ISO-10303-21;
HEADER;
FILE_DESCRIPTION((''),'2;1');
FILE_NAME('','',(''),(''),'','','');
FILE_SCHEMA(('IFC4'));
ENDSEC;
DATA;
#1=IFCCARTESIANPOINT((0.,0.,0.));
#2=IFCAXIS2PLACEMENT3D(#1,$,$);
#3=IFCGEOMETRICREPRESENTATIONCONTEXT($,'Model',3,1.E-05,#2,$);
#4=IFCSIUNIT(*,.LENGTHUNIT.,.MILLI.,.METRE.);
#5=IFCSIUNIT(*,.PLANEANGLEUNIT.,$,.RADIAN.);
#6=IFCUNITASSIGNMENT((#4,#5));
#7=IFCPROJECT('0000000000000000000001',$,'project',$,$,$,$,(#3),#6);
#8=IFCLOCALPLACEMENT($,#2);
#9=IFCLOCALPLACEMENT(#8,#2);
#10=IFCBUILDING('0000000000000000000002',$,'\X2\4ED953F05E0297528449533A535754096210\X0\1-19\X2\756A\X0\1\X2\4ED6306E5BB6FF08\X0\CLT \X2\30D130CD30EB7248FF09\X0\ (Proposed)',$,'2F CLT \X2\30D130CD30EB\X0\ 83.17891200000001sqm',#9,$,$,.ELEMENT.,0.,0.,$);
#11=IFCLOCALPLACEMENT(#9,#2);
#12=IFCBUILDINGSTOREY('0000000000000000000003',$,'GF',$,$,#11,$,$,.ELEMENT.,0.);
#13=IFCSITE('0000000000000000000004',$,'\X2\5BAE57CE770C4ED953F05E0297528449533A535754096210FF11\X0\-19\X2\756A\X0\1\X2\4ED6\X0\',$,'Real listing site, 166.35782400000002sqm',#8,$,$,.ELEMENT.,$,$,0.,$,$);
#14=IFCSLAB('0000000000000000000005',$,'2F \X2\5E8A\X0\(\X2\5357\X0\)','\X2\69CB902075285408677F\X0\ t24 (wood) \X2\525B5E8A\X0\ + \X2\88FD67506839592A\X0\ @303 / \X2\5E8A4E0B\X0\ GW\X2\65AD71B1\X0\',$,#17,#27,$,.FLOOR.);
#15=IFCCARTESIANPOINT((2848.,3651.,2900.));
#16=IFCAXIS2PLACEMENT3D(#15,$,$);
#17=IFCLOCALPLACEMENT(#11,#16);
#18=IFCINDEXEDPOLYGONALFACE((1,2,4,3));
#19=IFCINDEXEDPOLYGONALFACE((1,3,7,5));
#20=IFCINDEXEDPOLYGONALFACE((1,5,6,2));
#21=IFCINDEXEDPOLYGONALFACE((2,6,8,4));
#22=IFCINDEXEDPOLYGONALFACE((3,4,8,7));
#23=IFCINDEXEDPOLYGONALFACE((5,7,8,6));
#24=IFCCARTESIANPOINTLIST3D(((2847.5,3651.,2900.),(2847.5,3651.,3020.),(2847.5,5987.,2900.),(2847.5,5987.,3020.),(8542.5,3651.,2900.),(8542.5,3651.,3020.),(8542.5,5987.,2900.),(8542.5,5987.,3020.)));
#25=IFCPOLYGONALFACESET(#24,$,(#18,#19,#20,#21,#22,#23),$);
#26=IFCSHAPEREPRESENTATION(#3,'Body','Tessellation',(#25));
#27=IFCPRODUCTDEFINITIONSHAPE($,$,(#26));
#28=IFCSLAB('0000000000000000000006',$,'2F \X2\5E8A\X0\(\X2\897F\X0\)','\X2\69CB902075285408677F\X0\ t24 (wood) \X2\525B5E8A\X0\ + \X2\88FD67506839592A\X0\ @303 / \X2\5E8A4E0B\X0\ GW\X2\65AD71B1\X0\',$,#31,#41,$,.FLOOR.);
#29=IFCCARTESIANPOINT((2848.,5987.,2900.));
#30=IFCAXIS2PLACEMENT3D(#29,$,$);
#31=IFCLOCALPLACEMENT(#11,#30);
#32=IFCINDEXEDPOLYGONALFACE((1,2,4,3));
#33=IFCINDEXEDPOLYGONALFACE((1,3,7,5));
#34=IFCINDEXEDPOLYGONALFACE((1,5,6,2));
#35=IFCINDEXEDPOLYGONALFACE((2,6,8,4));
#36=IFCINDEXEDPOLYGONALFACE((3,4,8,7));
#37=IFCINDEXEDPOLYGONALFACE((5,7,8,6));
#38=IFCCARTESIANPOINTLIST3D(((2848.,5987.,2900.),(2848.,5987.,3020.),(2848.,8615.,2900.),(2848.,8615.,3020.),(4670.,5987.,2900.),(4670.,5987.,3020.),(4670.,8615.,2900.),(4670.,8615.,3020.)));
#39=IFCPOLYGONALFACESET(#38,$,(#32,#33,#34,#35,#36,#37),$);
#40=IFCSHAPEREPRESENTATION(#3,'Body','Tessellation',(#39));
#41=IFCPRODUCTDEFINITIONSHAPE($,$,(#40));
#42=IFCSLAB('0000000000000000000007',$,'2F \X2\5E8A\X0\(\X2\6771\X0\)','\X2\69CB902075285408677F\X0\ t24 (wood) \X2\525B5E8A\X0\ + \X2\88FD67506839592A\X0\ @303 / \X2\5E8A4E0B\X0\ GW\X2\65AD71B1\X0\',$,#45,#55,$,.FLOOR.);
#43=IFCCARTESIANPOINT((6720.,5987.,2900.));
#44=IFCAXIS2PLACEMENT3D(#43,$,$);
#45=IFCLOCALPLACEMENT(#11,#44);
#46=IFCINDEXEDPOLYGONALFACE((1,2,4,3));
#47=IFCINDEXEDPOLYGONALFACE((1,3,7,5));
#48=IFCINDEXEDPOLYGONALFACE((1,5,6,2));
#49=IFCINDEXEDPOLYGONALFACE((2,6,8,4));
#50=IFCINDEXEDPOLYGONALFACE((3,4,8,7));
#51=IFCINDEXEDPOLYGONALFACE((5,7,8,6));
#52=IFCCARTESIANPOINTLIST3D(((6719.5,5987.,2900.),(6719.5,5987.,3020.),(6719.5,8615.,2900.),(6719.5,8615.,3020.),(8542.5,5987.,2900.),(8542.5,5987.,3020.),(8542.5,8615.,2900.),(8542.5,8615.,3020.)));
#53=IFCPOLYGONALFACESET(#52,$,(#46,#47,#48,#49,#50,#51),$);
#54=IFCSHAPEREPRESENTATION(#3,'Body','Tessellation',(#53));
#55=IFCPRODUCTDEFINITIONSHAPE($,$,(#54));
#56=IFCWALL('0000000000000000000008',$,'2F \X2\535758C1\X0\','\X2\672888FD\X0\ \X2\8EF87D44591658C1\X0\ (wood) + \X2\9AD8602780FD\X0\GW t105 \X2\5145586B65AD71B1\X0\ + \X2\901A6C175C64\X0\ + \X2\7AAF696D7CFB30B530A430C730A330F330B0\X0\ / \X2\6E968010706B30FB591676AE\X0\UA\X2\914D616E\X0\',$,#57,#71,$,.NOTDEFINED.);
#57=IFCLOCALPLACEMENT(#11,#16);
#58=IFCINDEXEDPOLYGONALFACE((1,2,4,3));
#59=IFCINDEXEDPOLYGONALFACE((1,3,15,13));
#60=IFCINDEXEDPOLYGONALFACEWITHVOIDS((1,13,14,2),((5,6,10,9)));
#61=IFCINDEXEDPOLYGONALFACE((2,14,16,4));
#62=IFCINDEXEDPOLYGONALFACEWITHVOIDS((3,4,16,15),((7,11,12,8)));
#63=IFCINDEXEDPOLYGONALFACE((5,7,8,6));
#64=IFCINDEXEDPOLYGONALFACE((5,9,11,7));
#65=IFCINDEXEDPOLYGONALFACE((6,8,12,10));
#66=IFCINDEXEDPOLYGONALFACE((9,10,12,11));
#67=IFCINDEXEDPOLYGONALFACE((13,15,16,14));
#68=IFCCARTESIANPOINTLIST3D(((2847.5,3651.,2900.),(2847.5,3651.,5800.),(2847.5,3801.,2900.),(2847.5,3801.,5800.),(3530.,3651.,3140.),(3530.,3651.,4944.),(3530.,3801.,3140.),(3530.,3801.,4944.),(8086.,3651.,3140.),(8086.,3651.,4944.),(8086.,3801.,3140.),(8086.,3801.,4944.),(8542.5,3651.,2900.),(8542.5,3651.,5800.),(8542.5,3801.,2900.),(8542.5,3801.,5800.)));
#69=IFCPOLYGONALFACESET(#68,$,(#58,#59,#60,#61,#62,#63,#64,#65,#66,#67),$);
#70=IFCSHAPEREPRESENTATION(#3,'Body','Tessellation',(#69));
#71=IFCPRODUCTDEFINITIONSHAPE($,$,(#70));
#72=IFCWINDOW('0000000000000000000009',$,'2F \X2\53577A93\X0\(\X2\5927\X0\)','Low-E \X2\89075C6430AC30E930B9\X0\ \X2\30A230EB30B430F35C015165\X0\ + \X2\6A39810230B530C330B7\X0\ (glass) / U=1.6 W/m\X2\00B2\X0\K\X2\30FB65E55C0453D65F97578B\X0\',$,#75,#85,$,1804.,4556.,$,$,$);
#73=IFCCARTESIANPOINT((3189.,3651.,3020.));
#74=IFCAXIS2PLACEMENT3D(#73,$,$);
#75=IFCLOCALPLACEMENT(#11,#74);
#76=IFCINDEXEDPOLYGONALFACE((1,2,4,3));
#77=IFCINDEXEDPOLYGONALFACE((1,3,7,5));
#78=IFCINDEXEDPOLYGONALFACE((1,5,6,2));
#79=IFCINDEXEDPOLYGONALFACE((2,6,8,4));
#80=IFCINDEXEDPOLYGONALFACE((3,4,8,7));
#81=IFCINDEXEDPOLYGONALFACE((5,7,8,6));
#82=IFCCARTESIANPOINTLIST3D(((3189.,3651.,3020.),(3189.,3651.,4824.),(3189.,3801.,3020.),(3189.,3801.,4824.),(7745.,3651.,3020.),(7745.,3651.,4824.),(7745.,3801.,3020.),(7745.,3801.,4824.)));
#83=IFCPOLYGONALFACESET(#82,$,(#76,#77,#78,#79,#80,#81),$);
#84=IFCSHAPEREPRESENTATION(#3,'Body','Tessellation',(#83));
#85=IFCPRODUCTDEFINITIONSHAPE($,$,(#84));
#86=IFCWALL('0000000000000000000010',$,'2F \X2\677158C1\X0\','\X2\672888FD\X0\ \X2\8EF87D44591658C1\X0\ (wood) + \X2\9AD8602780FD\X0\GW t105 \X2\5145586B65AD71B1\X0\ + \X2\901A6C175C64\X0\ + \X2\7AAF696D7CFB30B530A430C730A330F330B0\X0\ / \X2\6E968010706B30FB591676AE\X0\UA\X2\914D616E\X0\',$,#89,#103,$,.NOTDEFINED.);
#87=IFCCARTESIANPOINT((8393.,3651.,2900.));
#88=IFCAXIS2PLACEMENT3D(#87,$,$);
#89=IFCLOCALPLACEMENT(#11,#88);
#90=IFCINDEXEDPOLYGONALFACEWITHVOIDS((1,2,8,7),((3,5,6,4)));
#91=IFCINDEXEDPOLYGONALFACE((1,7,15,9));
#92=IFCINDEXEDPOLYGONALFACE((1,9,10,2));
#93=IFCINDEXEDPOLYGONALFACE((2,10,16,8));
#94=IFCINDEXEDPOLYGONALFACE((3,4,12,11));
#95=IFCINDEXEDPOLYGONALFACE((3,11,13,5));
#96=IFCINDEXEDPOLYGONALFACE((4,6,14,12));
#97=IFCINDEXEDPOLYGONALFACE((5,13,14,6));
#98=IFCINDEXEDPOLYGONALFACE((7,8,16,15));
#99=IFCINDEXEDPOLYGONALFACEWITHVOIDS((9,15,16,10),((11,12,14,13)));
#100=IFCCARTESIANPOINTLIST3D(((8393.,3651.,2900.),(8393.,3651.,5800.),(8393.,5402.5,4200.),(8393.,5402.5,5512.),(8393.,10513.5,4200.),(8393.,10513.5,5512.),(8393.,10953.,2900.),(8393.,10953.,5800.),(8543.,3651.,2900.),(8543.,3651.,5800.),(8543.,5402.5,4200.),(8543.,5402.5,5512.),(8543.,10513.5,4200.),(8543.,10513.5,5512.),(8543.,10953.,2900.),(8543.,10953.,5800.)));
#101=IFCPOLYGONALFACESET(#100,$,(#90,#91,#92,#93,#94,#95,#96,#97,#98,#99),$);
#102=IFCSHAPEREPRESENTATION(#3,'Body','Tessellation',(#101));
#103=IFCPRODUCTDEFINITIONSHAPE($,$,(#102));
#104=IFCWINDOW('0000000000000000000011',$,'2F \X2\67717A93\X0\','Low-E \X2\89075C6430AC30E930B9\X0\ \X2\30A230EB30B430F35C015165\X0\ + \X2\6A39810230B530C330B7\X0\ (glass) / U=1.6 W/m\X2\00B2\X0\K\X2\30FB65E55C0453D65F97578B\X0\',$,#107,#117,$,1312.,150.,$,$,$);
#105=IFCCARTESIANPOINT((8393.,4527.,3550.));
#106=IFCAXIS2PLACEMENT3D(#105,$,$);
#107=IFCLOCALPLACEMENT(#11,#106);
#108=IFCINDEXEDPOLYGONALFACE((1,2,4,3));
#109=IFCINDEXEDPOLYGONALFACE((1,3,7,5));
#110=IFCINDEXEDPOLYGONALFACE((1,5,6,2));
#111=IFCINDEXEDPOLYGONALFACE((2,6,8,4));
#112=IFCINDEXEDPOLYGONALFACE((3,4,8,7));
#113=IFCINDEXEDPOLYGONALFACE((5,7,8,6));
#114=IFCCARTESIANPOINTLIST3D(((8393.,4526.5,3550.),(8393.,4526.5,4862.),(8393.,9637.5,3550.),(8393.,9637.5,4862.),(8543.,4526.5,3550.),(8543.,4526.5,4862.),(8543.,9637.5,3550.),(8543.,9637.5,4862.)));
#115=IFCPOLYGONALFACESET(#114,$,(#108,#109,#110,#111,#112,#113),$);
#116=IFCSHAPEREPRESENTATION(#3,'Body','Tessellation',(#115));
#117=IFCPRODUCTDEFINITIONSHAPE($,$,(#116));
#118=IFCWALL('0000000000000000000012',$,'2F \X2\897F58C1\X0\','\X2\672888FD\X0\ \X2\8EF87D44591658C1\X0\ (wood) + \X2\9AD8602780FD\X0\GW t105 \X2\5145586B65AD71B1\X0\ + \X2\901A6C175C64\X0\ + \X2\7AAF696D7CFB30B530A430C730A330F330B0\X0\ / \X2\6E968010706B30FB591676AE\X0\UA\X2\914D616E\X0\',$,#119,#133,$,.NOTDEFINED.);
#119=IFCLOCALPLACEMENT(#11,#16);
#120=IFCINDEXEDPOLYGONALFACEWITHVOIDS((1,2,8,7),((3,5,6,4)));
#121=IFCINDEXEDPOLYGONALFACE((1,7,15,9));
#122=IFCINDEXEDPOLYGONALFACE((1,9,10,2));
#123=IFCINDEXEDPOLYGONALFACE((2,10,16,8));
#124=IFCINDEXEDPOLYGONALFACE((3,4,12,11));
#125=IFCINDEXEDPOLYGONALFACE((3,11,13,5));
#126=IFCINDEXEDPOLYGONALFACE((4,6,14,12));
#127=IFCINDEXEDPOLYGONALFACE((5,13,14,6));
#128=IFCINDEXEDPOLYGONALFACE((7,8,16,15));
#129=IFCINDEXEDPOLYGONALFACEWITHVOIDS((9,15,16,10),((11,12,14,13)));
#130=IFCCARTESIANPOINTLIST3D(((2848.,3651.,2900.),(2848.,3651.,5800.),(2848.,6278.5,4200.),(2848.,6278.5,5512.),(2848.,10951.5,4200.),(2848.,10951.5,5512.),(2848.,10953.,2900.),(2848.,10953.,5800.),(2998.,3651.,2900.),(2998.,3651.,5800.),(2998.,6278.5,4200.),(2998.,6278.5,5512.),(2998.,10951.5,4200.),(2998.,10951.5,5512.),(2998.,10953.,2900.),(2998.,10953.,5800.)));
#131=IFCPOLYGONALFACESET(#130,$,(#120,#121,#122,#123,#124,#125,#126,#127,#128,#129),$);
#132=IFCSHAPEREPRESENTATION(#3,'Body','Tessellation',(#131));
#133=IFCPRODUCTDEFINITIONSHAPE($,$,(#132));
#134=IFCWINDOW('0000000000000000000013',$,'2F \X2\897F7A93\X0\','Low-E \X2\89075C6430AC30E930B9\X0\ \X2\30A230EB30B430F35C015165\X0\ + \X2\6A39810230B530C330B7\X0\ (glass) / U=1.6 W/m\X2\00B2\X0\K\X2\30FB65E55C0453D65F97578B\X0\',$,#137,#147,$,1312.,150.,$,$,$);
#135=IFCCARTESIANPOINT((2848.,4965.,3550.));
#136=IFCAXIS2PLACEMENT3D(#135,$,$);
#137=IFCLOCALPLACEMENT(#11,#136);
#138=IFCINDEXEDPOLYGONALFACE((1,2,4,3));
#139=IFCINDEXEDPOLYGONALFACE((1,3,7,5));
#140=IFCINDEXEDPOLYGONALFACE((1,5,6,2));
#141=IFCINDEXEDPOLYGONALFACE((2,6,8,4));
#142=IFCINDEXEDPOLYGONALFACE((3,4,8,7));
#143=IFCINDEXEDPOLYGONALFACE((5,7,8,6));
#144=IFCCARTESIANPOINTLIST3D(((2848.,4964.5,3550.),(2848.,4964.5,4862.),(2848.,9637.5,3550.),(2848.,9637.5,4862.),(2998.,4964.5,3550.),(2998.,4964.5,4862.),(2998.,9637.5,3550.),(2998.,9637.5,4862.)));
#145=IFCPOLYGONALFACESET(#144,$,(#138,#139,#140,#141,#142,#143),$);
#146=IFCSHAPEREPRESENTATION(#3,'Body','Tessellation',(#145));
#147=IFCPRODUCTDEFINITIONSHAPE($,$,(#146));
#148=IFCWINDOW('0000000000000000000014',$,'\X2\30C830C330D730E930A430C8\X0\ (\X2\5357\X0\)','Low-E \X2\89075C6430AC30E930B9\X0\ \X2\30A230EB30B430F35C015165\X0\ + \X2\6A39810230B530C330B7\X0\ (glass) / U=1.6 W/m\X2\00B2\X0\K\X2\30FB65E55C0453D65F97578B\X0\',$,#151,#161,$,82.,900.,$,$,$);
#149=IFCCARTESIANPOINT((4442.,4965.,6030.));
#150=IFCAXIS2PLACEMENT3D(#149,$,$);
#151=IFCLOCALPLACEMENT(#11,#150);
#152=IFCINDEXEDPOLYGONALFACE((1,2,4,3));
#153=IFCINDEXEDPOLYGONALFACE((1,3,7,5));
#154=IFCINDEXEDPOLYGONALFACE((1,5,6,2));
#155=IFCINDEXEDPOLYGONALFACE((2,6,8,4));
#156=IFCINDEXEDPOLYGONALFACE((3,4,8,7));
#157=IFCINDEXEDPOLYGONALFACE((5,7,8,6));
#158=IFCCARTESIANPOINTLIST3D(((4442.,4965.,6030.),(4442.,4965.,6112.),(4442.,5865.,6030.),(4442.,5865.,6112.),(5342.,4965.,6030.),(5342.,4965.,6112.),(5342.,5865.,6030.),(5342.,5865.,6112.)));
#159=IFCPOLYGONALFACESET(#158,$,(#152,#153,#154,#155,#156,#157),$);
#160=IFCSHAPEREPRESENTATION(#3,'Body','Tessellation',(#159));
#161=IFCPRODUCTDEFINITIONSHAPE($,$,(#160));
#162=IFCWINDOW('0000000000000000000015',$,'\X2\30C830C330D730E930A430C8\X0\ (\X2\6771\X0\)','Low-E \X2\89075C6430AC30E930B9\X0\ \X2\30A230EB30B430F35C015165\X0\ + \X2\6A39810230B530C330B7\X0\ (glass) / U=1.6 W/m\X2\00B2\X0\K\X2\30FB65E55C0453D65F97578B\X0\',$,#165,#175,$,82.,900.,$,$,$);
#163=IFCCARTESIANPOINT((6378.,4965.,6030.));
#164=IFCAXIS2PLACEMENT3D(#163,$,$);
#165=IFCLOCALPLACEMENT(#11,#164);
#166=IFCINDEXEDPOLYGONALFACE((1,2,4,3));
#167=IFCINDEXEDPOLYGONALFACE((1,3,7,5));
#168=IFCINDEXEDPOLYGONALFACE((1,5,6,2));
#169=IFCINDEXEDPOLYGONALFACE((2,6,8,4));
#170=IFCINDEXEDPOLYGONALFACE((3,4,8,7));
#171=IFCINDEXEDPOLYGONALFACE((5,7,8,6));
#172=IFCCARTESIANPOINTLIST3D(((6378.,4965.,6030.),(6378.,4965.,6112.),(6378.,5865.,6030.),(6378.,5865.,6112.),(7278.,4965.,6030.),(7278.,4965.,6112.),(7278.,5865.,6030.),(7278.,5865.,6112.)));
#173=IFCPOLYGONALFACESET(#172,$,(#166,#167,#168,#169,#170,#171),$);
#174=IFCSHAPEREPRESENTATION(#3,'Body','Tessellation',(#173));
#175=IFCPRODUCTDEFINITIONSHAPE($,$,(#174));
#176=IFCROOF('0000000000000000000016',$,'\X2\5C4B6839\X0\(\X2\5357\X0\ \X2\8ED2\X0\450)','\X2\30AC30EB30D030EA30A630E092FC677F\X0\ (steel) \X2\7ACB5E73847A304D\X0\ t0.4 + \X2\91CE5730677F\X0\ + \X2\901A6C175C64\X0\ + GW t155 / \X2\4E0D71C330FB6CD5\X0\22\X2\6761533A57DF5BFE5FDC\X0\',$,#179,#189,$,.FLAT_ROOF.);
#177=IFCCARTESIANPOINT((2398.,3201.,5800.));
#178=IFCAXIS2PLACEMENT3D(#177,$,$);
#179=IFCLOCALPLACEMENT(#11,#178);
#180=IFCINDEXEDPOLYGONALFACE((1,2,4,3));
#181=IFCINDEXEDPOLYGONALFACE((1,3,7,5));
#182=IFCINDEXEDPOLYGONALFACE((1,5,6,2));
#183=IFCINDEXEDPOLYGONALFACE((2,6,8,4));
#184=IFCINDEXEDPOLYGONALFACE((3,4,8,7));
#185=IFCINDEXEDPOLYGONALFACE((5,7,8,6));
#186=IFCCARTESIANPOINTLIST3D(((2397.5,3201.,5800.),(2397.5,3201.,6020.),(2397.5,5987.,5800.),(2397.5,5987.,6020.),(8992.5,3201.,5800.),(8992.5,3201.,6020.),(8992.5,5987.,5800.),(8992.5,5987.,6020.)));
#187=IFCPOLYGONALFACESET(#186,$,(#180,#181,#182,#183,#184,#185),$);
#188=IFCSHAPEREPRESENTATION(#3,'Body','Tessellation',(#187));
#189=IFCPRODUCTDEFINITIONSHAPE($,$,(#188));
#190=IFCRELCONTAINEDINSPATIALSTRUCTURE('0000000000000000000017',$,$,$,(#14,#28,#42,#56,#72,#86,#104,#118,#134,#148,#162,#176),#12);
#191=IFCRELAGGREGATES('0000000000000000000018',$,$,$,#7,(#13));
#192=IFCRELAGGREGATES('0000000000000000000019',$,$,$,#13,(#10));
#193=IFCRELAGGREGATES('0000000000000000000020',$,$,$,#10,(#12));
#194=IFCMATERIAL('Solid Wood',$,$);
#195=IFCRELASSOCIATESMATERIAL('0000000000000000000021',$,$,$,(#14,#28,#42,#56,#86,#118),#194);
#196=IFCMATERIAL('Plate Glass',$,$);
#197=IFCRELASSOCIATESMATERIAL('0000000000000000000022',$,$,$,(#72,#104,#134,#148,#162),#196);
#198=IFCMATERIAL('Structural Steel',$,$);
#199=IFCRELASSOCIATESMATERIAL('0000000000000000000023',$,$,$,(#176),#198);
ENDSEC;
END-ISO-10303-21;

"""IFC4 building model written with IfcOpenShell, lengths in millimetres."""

from ifc_helpers import new_model, si_unit, frame, frame_2d, origin, place, context, project, spatial, rectangle, extrude, material, element, fill, save


model = new_model("IFC4")

# Units and contexts
model_context = context("Model", 3, precision=1e-05, world=origin())
ifc_project = project(units=[si_unit("LENGTHUNIT", "METRE", prefix="MILLI"), si_unit("PLANEANGLEUNIT", "RADIAN")], contexts=[model_context])

# Site, building, storey
site_placement = place(None, origin())
site = spatial("IfcSite", under=ifc_project, at=site_placement, Name="宮城県仙台市青葉区南吉成１-19番1他", ObjectType="Real listing site, 166.35782400000002sqm", CompositionType="ELEMENT", RefElevation=0.0)
building_placement = place(site_placement, origin())
building = spatial("IfcBuilding", under=site, at=building_placement, Name="仙台市青葉区南吉成1-19番1他の家（CLT パネル版） (Proposed)", ObjectType="2F CLT パネル 83.17891200000001sqm", CompositionType="ELEMENT", ElevationOfRefHeight=0.0, ElevationOfTerrain=0.0)
storey_placement = place(building_placement, origin())
storey = spatial("IfcBuildingStorey", under=building, at=storey_placement, Name="GF", CompositionType="ELEMENT", Elevation=0.0)

# Slabs
ifc_material_1 = material(Name="Solid Wood")
slab_1_placement = place(storey_placement, frame((2848.0, 3651.0, 2900.0)))
element("IfcSlab", 1, at=slab_1_placement, inside=storey, material=ifc_material_1, Name="2F 床(南)", Description="構造用合板 t24 (wood) 剛床 + 製材根太 @303 / 床下 GW断熱", PredefinedType="FLOOR", context=model_context, shape_type="SweptSolid", body=[
    extrude(rectangle(XDim=5695.0, YDim=2336.0, at=frame_2d((2847.0, 1168.0))), frame((2848.0, 3651.0, 2900.0)), (0.0, 0.0, 1.0), 120.0),
])
slab_2_placement = place(storey_placement, frame((2848.0, 5987.0, 2900.0)))
element("IfcSlab", 2, at=slab_2_placement, inside=storey, material=ifc_material_1, Name="2F 床(西)", Description="構造用合板 t24 (wood) 剛床 + 製材根太 @303 / 床下 GW断熱", PredefinedType="FLOOR", context=model_context, shape_type="SweptSolid", body=[
    extrude(rectangle(XDim=1822.0, YDim=2628.0, at=frame_2d((911.0, 1314.0))), frame((2848.0, 5987.0, 2900.0)), (0.0, 0.0, 1.0), 120.0),
])
slab_3_placement = place(storey_placement, frame((6720.0, 5987.0, 2900.0)))
element("IfcSlab", 3, at=slab_3_placement, inside=storey, material=ifc_material_1, Name="2F 床(東)", Description="構造用合板 t24 (wood) 剛床 + 製材根太 @303 / 床下 GW断熱", PredefinedType="FLOOR", context=model_context, shape_type="SweptSolid", body=[
    extrude(rectangle(XDim=1823.0, YDim=2628.0, at=frame_2d((911.0, 1314.0))), frame((6720.0, 5987.0, 2900.0)), (0.0, 0.0, 1.0), 120.0),
])

# Walls, openings, windows
wall_1_placement = place(storey_placement, frame((2848.0, 3651.0, 2900.0)))
wall_1 = element("IfcWall", 4, at=wall_1_placement, inside=storey, material=ifc_material_1, Name="2F 南壁", Description="木製 軸組外壁 (wood) + 高性能GW t105 充填断熱 + 通気層 + 窯業系サイディング / 準耐火・外皮UA配慮", PredefinedType="NOTDEFINED", context=model_context, shape_type="SweptSolid", body=[
    extrude(rectangle(XDim=5695.0, YDim=150.0, at=frame_2d((2847.0, 75.0))), frame((2848.0, 3651.0, 2900.0)), (0.0, 0.0, 1.0), 2900.0),
])
opening_1_placement = place(storey_placement, frame((3189.0, 3651.0, 3020.0)))
opening_1 = element("IfcOpeningElement", 5, at=opening_1_placement, cuts=wall_1, PredefinedType="NOTDEFINED", context=model_context, shape_type="SweptSolid", body=[
    extrude(rectangle(XDim=4556.0, YDim=150.0, at=frame_2d((2278.0, 75.0))), frame((3189.0, 3651.0, 3020.0)), (0.0, 0.0, 1.0), 1804.0),
])
ifc_material_2 = material(Name="Plate Glass")
window_1_placement = place(storey_placement, frame((3189.0, 3651.0, 3020.0)))
window_1 = element("IfcWindow", 6, at=window_1_placement, inside=storey, material=ifc_material_2, Name="2F 南窓(大)", Description="Low-E 複層ガラス アルゴン封入 + 樹脂サッシ (glass) / U=1.6 W/m²K・日射取得型", OverallHeight=1804.0, OverallWidth=4556.0, context=model_context, shape_type="SweptSolid", body=[
    extrude(rectangle(XDim=4556.0, YDim=150.0, at=frame_2d((2278.0, 75.0))), frame((3189.0, 3651.0, 3020.0)), (0.0, 0.0, 1.0), 1804.0),
])
fill(opening_1, window_1)
wall_2_placement = place(storey_placement, frame((8393.0, 3651.0, 2900.0)))
wall_2 = element("IfcWall", 7, at=wall_2_placement, inside=storey, material=ifc_material_1, Name="2F 東壁", Description="木製 軸組外壁 (wood) + 高性能GW t105 充填断熱 + 通気層 + 窯業系サイディング / 準耐火・外皮UA配慮", PredefinedType="NOTDEFINED", context=model_context, shape_type="SweptSolid", body=[
    extrude(rectangle(XDim=150.0, YDim=7302.0, at=frame_2d((75.0, 3651.0))), frame((8393.0, 3651.0, 2900.0)), (0.0, 0.0, 1.0), 2900.0),
])
opening_2_placement = place(storey_placement, frame((8393.0, 4527.0, 3550.0)))
opening_2 = element("IfcOpeningElement", 8, at=opening_2_placement, cuts=wall_2, PredefinedType="NOTDEFINED", context=model_context, shape_type="SweptSolid", body=[
    extrude(rectangle(XDim=150.0, YDim=5111.0, at=frame_2d((75.0, 2555.0))), frame((8393.0, 4527.0, 3550.0)), (0.0, 0.0, 1.0), 1312.0),
])
window_2_placement = place(storey_placement, frame((8393.0, 4527.0, 3550.0)))
window_2 = element("IfcWindow", 9, at=window_2_placement, inside=storey, material=ifc_material_2, Name="2F 東窓", Description="Low-E 複層ガラス アルゴン封入 + 樹脂サッシ (glass) / U=1.6 W/m²K・日射取得型", OverallHeight=1312.0, OverallWidth=150.0, context=model_context, shape_type="SweptSolid", body=[
    extrude(rectangle(XDim=150.0, YDim=5111.0, at=frame_2d((75.0, 2555.0))), frame((8393.0, 4527.0, 3550.0)), (0.0, 0.0, 1.0), 1312.0),
])
fill(opening_2, window_2)
wall_3_placement = place(storey_placement, frame((2848.0, 3651.0, 2900.0)))
wall_3 = element("IfcWall", 10, at=wall_3_placement, inside=storey, material=ifc_material_1, Name="2F 西壁", Description="木製 軸組外壁 (wood) + 高性能GW t105 充填断熱 + 通気層 + 窯業系サイディング / 準耐火・外皮UA配慮", PredefinedType="NOTDEFINED", context=model_context, shape_type="SweptSolid", body=[
    extrude(rectangle(XDim=150.0, YDim=7302.0, at=frame_2d((75.0, 3651.0))), frame((2848.0, 3651.0, 2900.0)), (0.0, 0.0, 1.0), 2900.0),
])
opening_3_placement = place(storey_placement, frame((2848.0, 4965.0, 3550.0)))
opening_3 = element("IfcOpeningElement", 11, at=opening_3_placement, cuts=wall_3, PredefinedType="NOTDEFINED", context=model_context, shape_type="SweptSolid", body=[
    extrude(rectangle(XDim=150.0, YDim=4673.0, at=frame_2d((75.0, 2336.0))), frame((2848.0, 4965.0, 3550.0)), (0.0, 0.0, 1.0), 1312.0),
])
window_3_placement = place(storey_placement, frame((2848.0, 4965.0, 3550.0)))
window_3 = element("IfcWindow", 12, at=window_3_placement, inside=storey, material=ifc_material_2, Name="2F 西窓", Description="Low-E 複層ガラス アルゴン封入 + 樹脂サッシ (glass) / U=1.6 W/m²K・日射取得型", OverallHeight=1312.0, OverallWidth=150.0, context=model_context, shape_type="SweptSolid", body=[
    extrude(rectangle(XDim=150.0, YDim=4673.0, at=frame_2d((75.0, 2336.0))), frame((2848.0, 4965.0, 3550.0)), (0.0, 0.0, 1.0), 1312.0),
])
fill(opening_3, window_3)

# Windows
window_4_placement = place(storey_placement, frame((4442.0, 4965.0, 6030.0)))
element("IfcWindow", 13, at=window_4_placement, inside=storey, material=ifc_material_2, Name="トップライト (南)", Description="Low-E 複層ガラス アルゴン封入 + 樹脂サッシ (glass) / U=1.6 W/m²K・日射取得型", OverallHeight=82.0, OverallWidth=900.0, context=model_context, shape_type="SweptSolid", body=[
    extrude(rectangle(XDim=900.0, YDim=900.0, at=frame_2d((450.0, 450.0))), frame((4442.0, 4965.0, 6030.0)), (0.0, 0.0, 1.0), 82.0),
])
window_5_placement = place(storey_placement, frame((6378.0, 4965.0, 6030.0)))
element("IfcWindow", 14, at=window_5_placement, inside=storey, material=ifc_material_2, Name="トップライト (東)", Description="Low-E 複層ガラス アルゴン封入 + 樹脂サッシ (glass) / U=1.6 W/m²K・日射取得型", OverallHeight=82.0, OverallWidth=900.0, context=model_context, shape_type="SweptSolid", body=[
    extrude(rectangle(XDim=900.0, YDim=900.0, at=frame_2d((450.0, 450.0))), frame((6378.0, 4965.0, 6030.0)), (0.0, 0.0, 1.0), 82.0),
])

# Roof
ifc_material_3 = material(Name="Structural Steel")
roof_1_placement = place(storey_placement, frame((2398.0, 3201.0, 5800.0)))
element("IfcRoof", 15, at=roof_1_placement, inside=storey, material=ifc_material_3, Name="屋根(南 軒450)", Description="ガルバリウム鋼板 (steel) 立平葺き t0.4 + 野地板 + 通気層 + GW t155 / 不燃・法22条区域対応", PredefinedType="FLAT_ROOF", context=model_context, shape_type="SweptSolid", body=[
    extrude(rectangle(XDim=6595.0, YDim=2786.0, at=frame_2d((3297.0, 1393.0))), frame((2398.0, 3201.0, 5800.0)), (0.0, 0.0, 1.0), 220.0),
])

save(model, "model.ifc")
